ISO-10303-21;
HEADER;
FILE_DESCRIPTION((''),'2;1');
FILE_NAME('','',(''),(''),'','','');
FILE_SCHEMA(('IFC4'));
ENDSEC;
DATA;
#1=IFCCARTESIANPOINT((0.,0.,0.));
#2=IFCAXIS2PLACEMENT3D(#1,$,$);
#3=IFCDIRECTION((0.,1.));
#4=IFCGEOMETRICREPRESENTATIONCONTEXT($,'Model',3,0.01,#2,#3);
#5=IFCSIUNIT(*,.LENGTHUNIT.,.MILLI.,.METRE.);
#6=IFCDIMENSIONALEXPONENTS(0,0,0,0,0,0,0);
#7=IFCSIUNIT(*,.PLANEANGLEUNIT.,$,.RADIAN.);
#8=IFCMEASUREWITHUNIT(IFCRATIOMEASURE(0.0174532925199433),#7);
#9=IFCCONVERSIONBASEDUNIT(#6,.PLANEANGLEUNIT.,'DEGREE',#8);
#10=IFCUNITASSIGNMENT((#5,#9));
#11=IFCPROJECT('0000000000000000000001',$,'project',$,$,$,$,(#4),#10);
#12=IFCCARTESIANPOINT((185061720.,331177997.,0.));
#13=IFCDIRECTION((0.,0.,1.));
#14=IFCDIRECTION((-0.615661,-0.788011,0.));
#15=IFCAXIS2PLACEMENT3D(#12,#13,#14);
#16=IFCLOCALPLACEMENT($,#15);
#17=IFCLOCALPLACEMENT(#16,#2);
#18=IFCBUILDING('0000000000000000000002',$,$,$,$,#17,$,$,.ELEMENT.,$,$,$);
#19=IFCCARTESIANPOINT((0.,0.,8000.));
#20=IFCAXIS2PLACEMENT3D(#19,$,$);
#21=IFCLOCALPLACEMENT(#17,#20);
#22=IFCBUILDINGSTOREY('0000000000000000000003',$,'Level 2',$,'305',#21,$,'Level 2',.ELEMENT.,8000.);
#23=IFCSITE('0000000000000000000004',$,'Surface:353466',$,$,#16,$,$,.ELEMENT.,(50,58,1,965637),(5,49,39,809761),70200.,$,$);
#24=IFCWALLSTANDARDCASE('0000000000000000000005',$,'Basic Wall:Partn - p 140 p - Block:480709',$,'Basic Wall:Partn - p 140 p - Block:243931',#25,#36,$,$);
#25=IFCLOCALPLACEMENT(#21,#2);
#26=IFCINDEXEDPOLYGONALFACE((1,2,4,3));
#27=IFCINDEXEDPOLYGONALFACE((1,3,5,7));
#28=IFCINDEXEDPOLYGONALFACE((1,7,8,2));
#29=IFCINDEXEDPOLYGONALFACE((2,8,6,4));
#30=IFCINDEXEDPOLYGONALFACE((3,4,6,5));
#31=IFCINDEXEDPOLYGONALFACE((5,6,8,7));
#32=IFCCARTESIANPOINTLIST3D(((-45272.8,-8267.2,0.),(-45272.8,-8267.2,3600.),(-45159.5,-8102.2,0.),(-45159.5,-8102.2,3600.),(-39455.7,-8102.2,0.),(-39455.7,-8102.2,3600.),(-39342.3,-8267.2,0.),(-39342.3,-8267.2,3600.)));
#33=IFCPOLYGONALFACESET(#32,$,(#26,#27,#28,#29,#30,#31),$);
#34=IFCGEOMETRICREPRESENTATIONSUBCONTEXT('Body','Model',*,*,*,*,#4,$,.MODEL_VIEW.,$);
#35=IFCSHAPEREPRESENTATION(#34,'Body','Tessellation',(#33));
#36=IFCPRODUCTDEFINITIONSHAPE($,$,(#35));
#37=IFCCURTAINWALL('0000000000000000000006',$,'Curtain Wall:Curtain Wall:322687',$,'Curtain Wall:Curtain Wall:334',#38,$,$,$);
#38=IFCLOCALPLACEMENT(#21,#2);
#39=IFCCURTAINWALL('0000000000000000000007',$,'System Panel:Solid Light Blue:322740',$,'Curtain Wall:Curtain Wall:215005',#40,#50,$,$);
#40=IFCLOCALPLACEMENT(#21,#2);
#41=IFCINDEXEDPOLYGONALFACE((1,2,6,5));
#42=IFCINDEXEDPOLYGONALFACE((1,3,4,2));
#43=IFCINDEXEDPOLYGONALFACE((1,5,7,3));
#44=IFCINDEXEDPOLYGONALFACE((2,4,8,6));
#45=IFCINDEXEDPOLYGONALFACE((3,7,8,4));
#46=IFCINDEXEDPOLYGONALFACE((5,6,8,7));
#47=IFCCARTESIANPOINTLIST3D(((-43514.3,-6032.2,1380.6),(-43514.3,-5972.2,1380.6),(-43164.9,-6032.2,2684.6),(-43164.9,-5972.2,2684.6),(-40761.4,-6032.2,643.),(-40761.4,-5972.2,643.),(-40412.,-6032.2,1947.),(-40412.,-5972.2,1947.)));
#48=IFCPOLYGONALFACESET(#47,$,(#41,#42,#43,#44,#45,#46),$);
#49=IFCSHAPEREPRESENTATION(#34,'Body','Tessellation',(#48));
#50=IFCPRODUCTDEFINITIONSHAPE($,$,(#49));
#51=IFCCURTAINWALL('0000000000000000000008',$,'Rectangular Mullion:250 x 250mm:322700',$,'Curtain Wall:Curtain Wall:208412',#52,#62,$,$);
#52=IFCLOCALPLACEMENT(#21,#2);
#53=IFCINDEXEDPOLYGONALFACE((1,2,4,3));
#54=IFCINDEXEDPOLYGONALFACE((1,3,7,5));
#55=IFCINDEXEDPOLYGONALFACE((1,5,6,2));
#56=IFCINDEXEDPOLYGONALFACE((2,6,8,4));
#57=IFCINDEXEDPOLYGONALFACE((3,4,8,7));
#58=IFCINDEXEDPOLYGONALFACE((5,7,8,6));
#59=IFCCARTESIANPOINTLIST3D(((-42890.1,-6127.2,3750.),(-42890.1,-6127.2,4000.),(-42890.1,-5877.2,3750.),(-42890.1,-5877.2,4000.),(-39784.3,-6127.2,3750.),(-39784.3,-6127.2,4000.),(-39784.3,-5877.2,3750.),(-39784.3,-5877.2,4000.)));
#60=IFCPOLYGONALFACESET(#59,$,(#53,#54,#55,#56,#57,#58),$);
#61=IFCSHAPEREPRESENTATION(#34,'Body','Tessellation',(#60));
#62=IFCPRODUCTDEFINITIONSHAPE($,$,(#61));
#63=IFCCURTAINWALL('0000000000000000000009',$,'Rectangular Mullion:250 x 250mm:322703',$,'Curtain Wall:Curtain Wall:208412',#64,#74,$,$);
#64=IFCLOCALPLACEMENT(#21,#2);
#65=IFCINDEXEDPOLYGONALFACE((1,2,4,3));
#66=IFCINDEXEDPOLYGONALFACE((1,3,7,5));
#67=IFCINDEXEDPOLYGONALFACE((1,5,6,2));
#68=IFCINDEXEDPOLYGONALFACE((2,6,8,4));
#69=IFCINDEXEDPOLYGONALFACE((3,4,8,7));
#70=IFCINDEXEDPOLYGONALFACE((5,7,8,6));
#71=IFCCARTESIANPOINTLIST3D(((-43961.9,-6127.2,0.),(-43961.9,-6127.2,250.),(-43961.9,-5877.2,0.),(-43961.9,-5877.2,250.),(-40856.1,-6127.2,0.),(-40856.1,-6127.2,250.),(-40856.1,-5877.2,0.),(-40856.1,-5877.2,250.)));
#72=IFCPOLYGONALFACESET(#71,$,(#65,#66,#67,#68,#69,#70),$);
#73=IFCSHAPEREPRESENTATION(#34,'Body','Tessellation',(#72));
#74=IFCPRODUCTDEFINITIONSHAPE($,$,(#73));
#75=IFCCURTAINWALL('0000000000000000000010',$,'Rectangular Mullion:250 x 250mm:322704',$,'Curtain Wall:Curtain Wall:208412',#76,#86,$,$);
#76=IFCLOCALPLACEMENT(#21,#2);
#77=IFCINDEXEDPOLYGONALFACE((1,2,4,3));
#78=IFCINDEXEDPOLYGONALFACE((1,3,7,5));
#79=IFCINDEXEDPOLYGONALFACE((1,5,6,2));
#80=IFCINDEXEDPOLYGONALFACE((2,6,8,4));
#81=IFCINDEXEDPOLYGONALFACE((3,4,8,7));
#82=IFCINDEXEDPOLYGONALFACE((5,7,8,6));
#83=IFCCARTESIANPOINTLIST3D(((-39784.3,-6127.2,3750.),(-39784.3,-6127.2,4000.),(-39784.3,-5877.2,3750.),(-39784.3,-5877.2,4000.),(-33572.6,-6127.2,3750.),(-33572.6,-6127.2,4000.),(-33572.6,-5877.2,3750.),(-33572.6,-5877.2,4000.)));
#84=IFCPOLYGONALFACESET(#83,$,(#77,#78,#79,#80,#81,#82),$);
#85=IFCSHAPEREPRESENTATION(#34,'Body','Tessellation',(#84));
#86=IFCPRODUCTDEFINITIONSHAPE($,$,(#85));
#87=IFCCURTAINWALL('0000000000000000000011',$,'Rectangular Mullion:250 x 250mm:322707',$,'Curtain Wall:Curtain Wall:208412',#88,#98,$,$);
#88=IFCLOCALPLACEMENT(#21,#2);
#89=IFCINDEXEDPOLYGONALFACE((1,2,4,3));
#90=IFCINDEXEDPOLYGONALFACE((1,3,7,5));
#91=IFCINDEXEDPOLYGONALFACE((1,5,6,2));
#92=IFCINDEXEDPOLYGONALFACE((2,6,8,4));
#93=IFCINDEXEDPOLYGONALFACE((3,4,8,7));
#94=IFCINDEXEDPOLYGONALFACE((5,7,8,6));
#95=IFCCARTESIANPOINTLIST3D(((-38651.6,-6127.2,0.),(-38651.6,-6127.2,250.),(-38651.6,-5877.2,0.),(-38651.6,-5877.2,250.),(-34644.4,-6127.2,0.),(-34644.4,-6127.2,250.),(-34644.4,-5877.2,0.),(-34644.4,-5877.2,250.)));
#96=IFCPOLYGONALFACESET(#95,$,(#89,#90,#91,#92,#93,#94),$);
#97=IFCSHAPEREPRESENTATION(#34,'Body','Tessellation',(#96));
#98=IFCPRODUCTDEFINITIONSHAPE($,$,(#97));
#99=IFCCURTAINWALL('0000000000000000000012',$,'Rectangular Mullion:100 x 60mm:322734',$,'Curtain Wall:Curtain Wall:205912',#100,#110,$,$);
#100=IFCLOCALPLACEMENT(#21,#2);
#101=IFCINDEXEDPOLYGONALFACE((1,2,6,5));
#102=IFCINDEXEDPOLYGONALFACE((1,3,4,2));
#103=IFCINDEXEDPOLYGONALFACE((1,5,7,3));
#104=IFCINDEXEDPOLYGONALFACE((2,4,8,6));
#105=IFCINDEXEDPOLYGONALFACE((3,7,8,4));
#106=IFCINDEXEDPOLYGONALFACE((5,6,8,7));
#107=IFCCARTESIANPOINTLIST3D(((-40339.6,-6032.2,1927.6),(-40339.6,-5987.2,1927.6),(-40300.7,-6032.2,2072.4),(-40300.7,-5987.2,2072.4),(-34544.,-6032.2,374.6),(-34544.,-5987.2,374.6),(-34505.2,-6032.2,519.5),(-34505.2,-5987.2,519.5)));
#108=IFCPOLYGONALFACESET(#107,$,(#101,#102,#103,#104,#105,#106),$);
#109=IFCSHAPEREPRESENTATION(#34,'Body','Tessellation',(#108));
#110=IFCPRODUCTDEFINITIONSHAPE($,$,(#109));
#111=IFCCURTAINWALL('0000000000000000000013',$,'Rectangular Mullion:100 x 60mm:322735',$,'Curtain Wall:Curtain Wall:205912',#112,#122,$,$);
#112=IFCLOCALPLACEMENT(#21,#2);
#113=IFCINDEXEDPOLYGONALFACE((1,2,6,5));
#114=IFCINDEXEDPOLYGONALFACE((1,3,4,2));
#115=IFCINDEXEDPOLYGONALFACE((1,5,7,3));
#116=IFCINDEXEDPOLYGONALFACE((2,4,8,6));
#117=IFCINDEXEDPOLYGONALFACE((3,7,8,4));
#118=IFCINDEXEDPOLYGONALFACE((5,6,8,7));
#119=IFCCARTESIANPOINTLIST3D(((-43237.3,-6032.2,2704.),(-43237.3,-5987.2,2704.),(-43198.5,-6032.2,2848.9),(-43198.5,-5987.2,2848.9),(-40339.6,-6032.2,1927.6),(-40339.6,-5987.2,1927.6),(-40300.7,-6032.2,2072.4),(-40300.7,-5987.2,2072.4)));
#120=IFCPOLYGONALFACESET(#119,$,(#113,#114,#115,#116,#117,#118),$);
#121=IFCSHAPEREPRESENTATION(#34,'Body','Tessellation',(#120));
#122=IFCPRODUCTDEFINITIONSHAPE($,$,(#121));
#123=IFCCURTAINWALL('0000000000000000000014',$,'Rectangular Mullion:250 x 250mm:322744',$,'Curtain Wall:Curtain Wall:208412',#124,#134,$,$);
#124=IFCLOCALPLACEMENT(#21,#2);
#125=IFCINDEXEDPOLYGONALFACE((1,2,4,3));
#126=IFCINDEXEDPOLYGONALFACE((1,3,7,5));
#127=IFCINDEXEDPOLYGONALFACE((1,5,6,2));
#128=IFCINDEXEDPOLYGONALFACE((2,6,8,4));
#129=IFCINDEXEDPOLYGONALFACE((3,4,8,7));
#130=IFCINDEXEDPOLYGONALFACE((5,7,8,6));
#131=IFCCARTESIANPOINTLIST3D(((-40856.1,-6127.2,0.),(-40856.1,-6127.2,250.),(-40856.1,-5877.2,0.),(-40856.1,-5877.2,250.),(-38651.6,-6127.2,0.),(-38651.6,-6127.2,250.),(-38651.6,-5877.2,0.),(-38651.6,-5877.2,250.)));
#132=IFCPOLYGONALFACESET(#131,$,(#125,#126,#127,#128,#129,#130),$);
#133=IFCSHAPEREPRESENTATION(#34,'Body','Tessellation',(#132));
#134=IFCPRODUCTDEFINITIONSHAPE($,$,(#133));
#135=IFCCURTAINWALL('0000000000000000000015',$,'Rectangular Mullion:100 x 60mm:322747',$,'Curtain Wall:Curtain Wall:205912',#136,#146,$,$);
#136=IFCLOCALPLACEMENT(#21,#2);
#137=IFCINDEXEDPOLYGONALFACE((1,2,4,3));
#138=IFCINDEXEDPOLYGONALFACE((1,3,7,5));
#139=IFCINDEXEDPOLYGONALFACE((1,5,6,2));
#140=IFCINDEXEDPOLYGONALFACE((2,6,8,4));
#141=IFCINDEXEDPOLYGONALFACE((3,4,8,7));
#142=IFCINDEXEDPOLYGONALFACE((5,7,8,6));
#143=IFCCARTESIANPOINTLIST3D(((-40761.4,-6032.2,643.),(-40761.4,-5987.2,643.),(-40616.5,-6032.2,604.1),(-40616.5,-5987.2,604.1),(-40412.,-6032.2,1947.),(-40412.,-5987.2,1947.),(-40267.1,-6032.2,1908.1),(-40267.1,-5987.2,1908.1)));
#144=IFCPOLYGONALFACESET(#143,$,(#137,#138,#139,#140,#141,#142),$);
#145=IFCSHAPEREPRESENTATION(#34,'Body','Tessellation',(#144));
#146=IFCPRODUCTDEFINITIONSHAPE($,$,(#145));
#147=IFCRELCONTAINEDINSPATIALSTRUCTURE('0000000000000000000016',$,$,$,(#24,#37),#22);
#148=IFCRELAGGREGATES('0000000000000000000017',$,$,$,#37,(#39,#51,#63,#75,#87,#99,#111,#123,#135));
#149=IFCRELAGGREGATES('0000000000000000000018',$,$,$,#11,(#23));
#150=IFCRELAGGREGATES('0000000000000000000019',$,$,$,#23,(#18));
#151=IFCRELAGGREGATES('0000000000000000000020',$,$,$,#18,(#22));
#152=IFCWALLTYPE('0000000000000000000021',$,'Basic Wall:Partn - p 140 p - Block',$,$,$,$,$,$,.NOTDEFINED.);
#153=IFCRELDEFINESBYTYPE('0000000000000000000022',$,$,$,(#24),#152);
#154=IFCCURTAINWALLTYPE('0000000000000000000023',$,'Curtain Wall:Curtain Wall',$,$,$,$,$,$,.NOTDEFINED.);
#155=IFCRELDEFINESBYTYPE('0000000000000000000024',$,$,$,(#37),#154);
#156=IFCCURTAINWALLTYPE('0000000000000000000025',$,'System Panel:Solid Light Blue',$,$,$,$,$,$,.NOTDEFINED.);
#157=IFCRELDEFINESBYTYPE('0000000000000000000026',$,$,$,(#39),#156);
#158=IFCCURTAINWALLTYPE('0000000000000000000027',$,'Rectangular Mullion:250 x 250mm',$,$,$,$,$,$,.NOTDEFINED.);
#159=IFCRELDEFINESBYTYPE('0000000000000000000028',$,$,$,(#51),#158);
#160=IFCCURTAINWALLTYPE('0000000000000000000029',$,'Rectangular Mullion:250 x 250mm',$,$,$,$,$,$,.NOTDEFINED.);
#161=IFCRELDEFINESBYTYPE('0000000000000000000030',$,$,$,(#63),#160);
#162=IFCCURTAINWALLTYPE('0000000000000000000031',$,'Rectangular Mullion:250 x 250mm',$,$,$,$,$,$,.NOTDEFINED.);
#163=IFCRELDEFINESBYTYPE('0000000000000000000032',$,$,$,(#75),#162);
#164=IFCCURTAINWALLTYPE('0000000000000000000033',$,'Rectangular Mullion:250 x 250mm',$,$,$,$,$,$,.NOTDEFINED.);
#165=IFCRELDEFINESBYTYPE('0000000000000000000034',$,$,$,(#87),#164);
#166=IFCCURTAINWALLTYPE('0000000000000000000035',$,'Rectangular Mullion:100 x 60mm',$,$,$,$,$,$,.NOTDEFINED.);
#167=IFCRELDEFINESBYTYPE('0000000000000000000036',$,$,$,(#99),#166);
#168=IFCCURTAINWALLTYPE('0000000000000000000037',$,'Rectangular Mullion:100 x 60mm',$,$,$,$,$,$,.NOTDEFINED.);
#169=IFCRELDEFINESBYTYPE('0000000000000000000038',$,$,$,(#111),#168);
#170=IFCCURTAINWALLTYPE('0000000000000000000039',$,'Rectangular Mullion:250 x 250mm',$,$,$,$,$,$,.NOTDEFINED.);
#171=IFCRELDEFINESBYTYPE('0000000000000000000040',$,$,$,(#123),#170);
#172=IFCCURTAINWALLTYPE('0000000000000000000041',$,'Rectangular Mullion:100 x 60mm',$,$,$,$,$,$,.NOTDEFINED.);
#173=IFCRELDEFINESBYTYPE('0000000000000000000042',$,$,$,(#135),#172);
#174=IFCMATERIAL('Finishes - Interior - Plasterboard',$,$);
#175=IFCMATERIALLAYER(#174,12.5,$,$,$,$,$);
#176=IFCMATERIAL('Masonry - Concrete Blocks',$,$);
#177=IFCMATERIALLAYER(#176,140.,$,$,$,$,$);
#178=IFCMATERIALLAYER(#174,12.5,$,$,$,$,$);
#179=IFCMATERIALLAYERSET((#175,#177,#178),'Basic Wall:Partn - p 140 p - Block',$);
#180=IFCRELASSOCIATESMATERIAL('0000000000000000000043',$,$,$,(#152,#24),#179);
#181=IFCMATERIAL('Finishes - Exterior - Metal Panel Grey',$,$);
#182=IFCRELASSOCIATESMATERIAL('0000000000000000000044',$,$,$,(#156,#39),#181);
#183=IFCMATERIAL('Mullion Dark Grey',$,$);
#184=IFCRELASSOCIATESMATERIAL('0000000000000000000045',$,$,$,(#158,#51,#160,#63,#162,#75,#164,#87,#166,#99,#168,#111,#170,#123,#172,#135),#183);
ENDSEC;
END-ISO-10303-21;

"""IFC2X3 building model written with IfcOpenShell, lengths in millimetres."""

from ifc_helpers import new_model, entity, si_unit, converted_unit, direction, frame, frame_2d, origin, origin_2d_with_axis, place, context, subcontext, project, spatial, polyline, rectangle, outline, extrude, clip, bounded_halfspace, source, transform, mapped, material, layer, layer_set, layer_usage, type_object, type_shapes, element, aggregate, save


model = new_model("IFC2X3")

# Units and contexts
model_context = context("Model", 3, precision=0.01, world=origin(), true_north=direction((0.0, 1.0)))
body_context = subcontext(model_context, "Body", "Model", "MODEL_VIEW")
ifc_project = project(units=[si_unit("LENGTHUNIT", "METRE", prefix="MILLI"), converted_unit("PLANEANGLEUNIT", "DEGREE", entity("IfcRatioMeasure", 0.0174532925199433), si_unit("PLANEANGLEUNIT", "RADIAN"), dimensions=[0, 0, 0, 0, 0, 0, 0])], contexts=[model_context])

# Site, building, storey
site_placement = place(None, frame((185061720.0, 331177997.0, 0.0), z_axis=(0.0, 0.0, 1.0), x_axis=(-0.615661, -0.788011, 0.0)))
site = spatial("IfcSite", under=ifc_project, at=site_placement, Name="Surface:353466", CompositionType="ELEMENT", RefLatitude=(50, 58, 1, 965637), RefLongitude=(5, 49, 39, 809761), RefElevation=70200.0)
building_placement = place(site_placement, origin())
building = spatial("IfcBuilding", under=site, at=building_placement, CompositionType="ELEMENT")
storey_placement = place(building_placement, frame((0.0, 0.0, 8000.0)))
storey = spatial("IfcBuildingStorey", under=building, at=storey_placement, Name="Level 2", ObjectType="305", LongName="Level 2", CompositionType="ELEMENT", Elevation=8000.0)

# Wall
ifc_material_1 = material(Name="Finishes - Interior - Plasterboard")
ifc_layer_1 = layer(ifc_material_1, 12.5)
ifc_material_2 = material(Name="Masonry - Concrete Blocks")
ifc_layer_2 = layer(ifc_material_2, 140.0)
ifc_layer_3 = layer(ifc_material_1, 12.5)
ifc_layer_set = layer_set([ifc_layer_1, ifc_layer_2, ifc_layer_3], Name="Basic Wall:Partn - p 140 p - Block")
ifc_layer_usage = layer_usage(ifc_layer_set, "AXIS2", "NEGATIVE", 82.5)
wall_type = type_object("IfcWallType", Name="Basic Wall:Partn - p 140 p - Block", PredefinedType="NOTDEFINED", material=ifc_layer_set)
wall_placement = place(storey_placement, frame((-39342.3, -8184.7, 0.0), z_axis=(0.0, 0.0, 1.0), x_axis=(-1.0, 0.0, 0.0)))
element("IfcWallStandardCase", 1, at=wall_placement, inside=storey, type_object=wall_type, material=ifc_layer_usage, Name="Basic Wall:Partn - p 140 p - Block:480709", ObjectType="Basic Wall:Partn - p 140 p - Block:243931", context=body_context, shape_type="Clipping", body=[
    clip(extrude(outline(polyline([(5817.2, -82.5), (5930.5, 82.5), (5778.8, 82.5), (3047.7, 82.5), (2882.7, 82.5), (151.6, 82.5), (0.0, 82.5), (113.3, -82.5), (5817.2, -82.5)])), origin(), (0.0, 0.0, 1.0), 3600.0), bounded_halfspace(frame((113.3, -82.5, 3600.0), z_axis=(0.0, 0.0, -1.0), x_axis=(-1.0, 0.0, 0.0)), True, frame((113.3, -82.5, 3600.0)), polyline([(0.0, 0.0), (5703.8, 0.0), (5817.2, 165.0), (5665.5, 165.0), (2934.4, 165.0), (2769.4, 165.0), (38.3, 165.0), (-113.3, 165.0), (0.0, 0.0)]))),
])

# Curtain walls
curtain_wall_type_1 = type_object("IfcCurtainWallType", Name="Curtain Wall:Curtain Wall", PredefinedType="NOTDEFINED")
curtain_wall_1_placement = place(storey_placement, frame((0.0, 0.0, -8000.0)))
curtain_wall_1 = element("IfcCurtainWall", 2, at=curtain_wall_1_placement, inside=storey, type_object=curtain_wall_type_1, Name="Curtain Wall:Curtain Wall:322687", ObjectType="Curtain Wall:Curtain Wall:334")
ifc_material_3 = material(Name="Finishes - Exterior - Metal Panel Grey")
curtain_wall_type_2 = type_object("IfcCurtainWallType", Name="System Panel:Solid Light Blue", PredefinedType="NOTDEFINED", material=ifc_material_3)
shared_shape_1 = source(origin(), body_context, "Body", "SweptSolid", [
    extrude(rectangle(XDim=60.0, YDim=2850.0, at=frame_2d((0.0, 0.0), x_axis=(1.0, 0.0))), frame((0.0, 0.0, 0.0), z_axis=(0.0, 0.0, 1.0), x_axis=(0.0, 1.0, 0.0)), (0.0, 0.0, 1.0), 1350.0),
])
type_shapes(curtain_wall_type_2, [shared_shape_1])
curtain_wall_2_placement = place(storey_placement, frame((-42137.9, -6002.2, 1011.8), z_axis=(0.258819, 0.0, 0.965926), x_axis=(-0.965926, 0.0, 0.258819)))
curtain_wall_2 = element("IfcCurtainWall", 3, at=curtain_wall_2_placement, type_object=curtain_wall_type_2, material=ifc_material_3, Name="System Panel:Solid Light Blue:322740", ObjectType="Curtain Wall:Curtain Wall:215005", context=body_context, shape_type="MappedRepresentation", body=[
    mapped(shared_shape_1, transform((0.0, 0.0, 0.0), scale=1.0)),
])
ifc_material_4 = material(Name="Mullion Dark Grey")
curtain_wall_type_3 = type_object("IfcCurtainWallType", Name="Rectangular Mullion:250 x 250mm", PredefinedType="NOTDEFINED", material=ifc_material_4)
shared_shape_2 = source(origin(), body_context, "Body", "SweptSolid", [
    extrude(rectangle(XDim=250.0, YDim=250.0, at=origin_2d_with_axis()), frame((-125.0, 0.0, -3105.8), z_axis=(0.0, 0.0, 1.0), x_axis=(-1.0, 0.0, 0.0)), (0.0, 0.0, 1.0), 3105.8),
])
type_shapes(curtain_wall_type_3, [shared_shape_2])
curtain_wall_3_placement = place(storey_placement, frame((-42890.1, -6002.2, 4000.0), z_axis=(-1.0, 0.0, 0.0), x_axis=(0.0, 0.0, 1.0)))
curtain_wall_3 = element("IfcCurtainWall", 4, at=curtain_wall_3_placement, type_object=curtain_wall_type_3, material=ifc_material_4, Name="Rectangular Mullion:250 x 250mm:322700", ObjectType="Curtain Wall:Curtain Wall:208412", context=body_context, shape_type="MappedRepresentation", body=[
    mapped(shared_shape_2, transform((0.0, 0.0, 0.0), scale=1.0)),
])
curtain_wall_type_4 = type_object("IfcCurtainWallType", Name="Rectangular Mullion:250 x 250mm", PredefinedType="NOTDEFINED", material=ifc_material_4)
shared_shape_3 = source(origin(), body_context, "Body", "SweptSolid", [
    extrude(rectangle(XDim=250.0, YDim=250.0, at=origin_2d_with_axis()), frame((-125.0, 0.0, -3105.8), z_axis=(0.0, 0.0, 1.0), x_axis=(-1.0, 0.0, 0.0)), (0.0, 0.0, 1.0), 3105.8),
])
type_shapes(curtain_wall_type_4, [shared_shape_3])
curtain_wall_4_placement = place(storey_placement, frame((-40856.1, -6002.2, 0.0), z_axis=(1.0, 0.0, 0.0), x_axis=(0.0, 0.0, -1.0)))
curtain_wall_4 = element("IfcCurtainWall", 5, at=curtain_wall_4_placement, type_object=curtain_wall_type_4, material=ifc_material_4, Name="Rectangular Mullion:250 x 250mm:322703", ObjectType="Curtain Wall:Curtain Wall:208412", context=body_context, shape_type="MappedRepresentation", body=[
    mapped(shared_shape_3, transform((0.0, 0.0, 0.0), scale=1.0)),
])
curtain_wall_type_5 = type_object("IfcCurtainWallType", Name="Rectangular Mullion:250 x 250mm", PredefinedType="NOTDEFINED", material=ifc_material_4)
shared_shape_4 = source(origin(), body_context, "Body", "SweptSolid", [
    extrude(rectangle(XDim=250.0, YDim=250.0, at=origin_2d_with_axis()), frame((-125.0, 0.0, -6211.7), z_axis=(0.0, 0.0, 1.0), x_axis=(-1.0, 0.0, 0.0)), (0.0, 0.0, 1.0), 6211.7),
])
type_shapes(curtain_wall_type_5, [shared_shape_4])
curtain_wall_5_placement = place(storey_placement, frame((-39784.3, -6002.2, 4000.0), z_axis=(-1.0, 0.0, 0.0), x_axis=(0.0, 0.0, 1.0)))
curtain_wall_5 = element("IfcCurtainWall", 6, at=curtain_wall_5_placement, type_object=curtain_wall_type_5, material=ifc_material_4, Name="Rectangular Mullion:250 x 250mm:322704", ObjectType="Curtain Wall:Curtain Wall:208412", context=body_context, shape_type="MappedRepresentation", body=[
    mapped(shared_shape_4, transform((0.0, 0.0, 0.0), scale=1.0)),
])
curtain_wall_type_6 = type_object("IfcCurtainWallType", Name="Rectangular Mullion:250 x 250mm", PredefinedType="NOTDEFINED", material=ifc_material_4)
shared_shape_5 = source(origin(), body_context, "Body", "SweptSolid", [
    extrude(rectangle(XDim=250.0, YDim=250.0, at=origin_2d_with_axis()), frame((-125.0, 0.0, -4007.2), z_axis=(0.0, 0.0, 1.0), x_axis=(-1.0, 0.0, 0.0)), (0.0, 0.0, 1.0), 4007.2),
])
type_shapes(curtain_wall_type_6, [shared_shape_5])
curtain_wall_6_placement = place(storey_placement, frame((-34644.4, -6002.2, 0.0), z_axis=(1.0, 0.0, 0.0), x_axis=(0.0, 0.0, -1.0)))
curtain_wall_6 = element("IfcCurtainWall", 7, at=curtain_wall_6_placement, type_object=curtain_wall_type_6, material=ifc_material_4, Name="Rectangular Mullion:250 x 250mm:322707", ObjectType="Curtain Wall:Curtain Wall:208412", context=body_context, shape_type="MappedRepresentation", body=[
    mapped(shared_shape_5, transform((0.0, 0.0, 0.0), scale=1.0)),
])
curtain_wall_type_7 = type_object("IfcCurtainWallType", Name="Rectangular Mullion:100 x 60mm", PredefinedType="NOTDEFINED", material=ifc_material_4)
shared_shape_6 = source(origin(), body_context, "Body", "SweptSolid", [
    extrude(rectangle(XDim=150.0, YDim=45.0, at=frame_2d((0.0, 0.0), x_axis=(1.0, 0.0))), frame((0.0, -7.5, -6000.0)), (0.0, 0.0, 1.0), 6000.0),
])
type_shapes(curtain_wall_type_7, [shared_shape_6])
curtain_wall_7_placement = place(storey_placement, frame((-40320.2, -6002.2, 2000.0), z_axis=(-0.965926, 0.0, 0.258819), x_axis=(0.258819, 0.0, 0.965926)))
curtain_wall_7 = element("IfcCurtainWall", 8, at=curtain_wall_7_placement, type_object=curtain_wall_type_7, material=ifc_material_4, Name="Rectangular Mullion:100 x 60mm:322734", ObjectType="Curtain Wall:Curtain Wall:205912", context=body_context, shape_type="MappedRepresentation", body=[
    mapped(shared_shape_6, transform((0.0, 0.0, 0.0), scale=1.0)),
])
curtain_wall_type_8 = type_object("IfcCurtainWallType", Name="Rectangular Mullion:100 x 60mm", PredefinedType="NOTDEFINED", material=ifc_material_4)
shared_shape_7 = source(origin(), body_context, "Body", "SweptSolid", [
    extrude(rectangle(XDim=150.0, YDim=45.0, at=frame_2d((0.0, 0.0), x_axis=(1.0, 0.0))), frame((0.0, -7.5, -3000.0)), (0.0, 0.0, 1.0), 3000.0),
])
type_shapes(curtain_wall_type_8, [shared_shape_7])
curtain_wall_8_placement = place(storey_placement, frame((-43217.9, -6002.2, 2776.5), z_axis=(-0.965926, 0.0, 0.258819), x_axis=(0.258819, 0.0, 0.965926)))
curtain_wall_8 = element("IfcCurtainWall", 9, at=curtain_wall_8_placement, type_object=curtain_wall_type_8, material=ifc_material_4, Name="Rectangular Mullion:100 x 60mm:322735", ObjectType="Curtain Wall:Curtain Wall:205912", context=body_context, shape_type="MappedRepresentation", body=[
    mapped(shared_shape_7, transform((0.0, 0.0, 0.0), scale=1.0)),
])
curtain_wall_type_9 = type_object("IfcCurtainWallType", Name="Rectangular Mullion:250 x 250mm", PredefinedType="NOTDEFINED", material=ifc_material_4)
shared_shape_8 = source(origin(), body_context, "Body", "SweptSolid", [
    extrude(rectangle(XDim=250.0, YDim=250.0, at=origin_2d_with_axis()), frame((-125.0, 0.0, -2204.4), z_axis=(0.0, 0.0, 1.0), x_axis=(-1.0, 0.0, 0.0)), (0.0, 0.0, 1.0), 2204.4),
])
type_shapes(curtain_wall_type_9, [shared_shape_8])
curtain_wall_9_placement = place(storey_placement, frame((-38651.6, -6002.2, 0.0), z_axis=(1.0, 0.0, 0.0), x_axis=(0.0, 0.0, -1.0)))
curtain_wall_9 = element("IfcCurtainWall", 10, at=curtain_wall_9_placement, type_object=curtain_wall_type_9, material=ifc_material_4, Name="Rectangular Mullion:250 x 250mm:322744", ObjectType="Curtain Wall:Curtain Wall:208412", context=body_context, shape_type="MappedRepresentation", body=[
    mapped(shared_shape_8, transform((0.0, 0.0, 0.0), scale=1.0)),
])
curtain_wall_type_10 = type_object("IfcCurtainWallType", Name="Rectangular Mullion:100 x 60mm", PredefinedType="NOTDEFINED", material=ifc_material_4)
shared_shape_9 = source(origin(), body_context, "Body", "SweptSolid", [
    extrude(rectangle(XDim=150.0, YDim=45.0, at=frame_2d((0.0, 0.0), x_axis=(1.0, 0.0))), frame((0.0, -7.5, -1350.0)), (0.0, 0.0, 1.0), 1350.0),
])
type_shapes(curtain_wall_type_10, [shared_shape_9])
curtain_wall_10_placement = place(storey_placement, frame((-40689.0, -6002.2, 623.6), z_axis=(-0.258819, 0.0, -0.965926), x_axis=(-0.965926, 0.0, 0.258819)))
curtain_wall_10 = element("IfcCurtainWall", 11, at=curtain_wall_10_placement, type_object=curtain_wall_type_10, material=ifc_material_4, Name="Rectangular Mullion:100 x 60mm:322747", ObjectType="Curtain Wall:Curtain Wall:205912", context=body_context, shape_type="MappedRepresentation", body=[
    mapped(shared_shape_9, transform((0.0, 0.0, 0.0), scale=1.0)),
])
aggregate(curtain_wall_1, [curtain_wall_2, curtain_wall_3, curtain_wall_4, curtain_wall_5, curtain_wall_6, curtain_wall_7, curtain_wall_8, curtain_wall_9, curtain_wall_10])

save(model, "model.ifc")
